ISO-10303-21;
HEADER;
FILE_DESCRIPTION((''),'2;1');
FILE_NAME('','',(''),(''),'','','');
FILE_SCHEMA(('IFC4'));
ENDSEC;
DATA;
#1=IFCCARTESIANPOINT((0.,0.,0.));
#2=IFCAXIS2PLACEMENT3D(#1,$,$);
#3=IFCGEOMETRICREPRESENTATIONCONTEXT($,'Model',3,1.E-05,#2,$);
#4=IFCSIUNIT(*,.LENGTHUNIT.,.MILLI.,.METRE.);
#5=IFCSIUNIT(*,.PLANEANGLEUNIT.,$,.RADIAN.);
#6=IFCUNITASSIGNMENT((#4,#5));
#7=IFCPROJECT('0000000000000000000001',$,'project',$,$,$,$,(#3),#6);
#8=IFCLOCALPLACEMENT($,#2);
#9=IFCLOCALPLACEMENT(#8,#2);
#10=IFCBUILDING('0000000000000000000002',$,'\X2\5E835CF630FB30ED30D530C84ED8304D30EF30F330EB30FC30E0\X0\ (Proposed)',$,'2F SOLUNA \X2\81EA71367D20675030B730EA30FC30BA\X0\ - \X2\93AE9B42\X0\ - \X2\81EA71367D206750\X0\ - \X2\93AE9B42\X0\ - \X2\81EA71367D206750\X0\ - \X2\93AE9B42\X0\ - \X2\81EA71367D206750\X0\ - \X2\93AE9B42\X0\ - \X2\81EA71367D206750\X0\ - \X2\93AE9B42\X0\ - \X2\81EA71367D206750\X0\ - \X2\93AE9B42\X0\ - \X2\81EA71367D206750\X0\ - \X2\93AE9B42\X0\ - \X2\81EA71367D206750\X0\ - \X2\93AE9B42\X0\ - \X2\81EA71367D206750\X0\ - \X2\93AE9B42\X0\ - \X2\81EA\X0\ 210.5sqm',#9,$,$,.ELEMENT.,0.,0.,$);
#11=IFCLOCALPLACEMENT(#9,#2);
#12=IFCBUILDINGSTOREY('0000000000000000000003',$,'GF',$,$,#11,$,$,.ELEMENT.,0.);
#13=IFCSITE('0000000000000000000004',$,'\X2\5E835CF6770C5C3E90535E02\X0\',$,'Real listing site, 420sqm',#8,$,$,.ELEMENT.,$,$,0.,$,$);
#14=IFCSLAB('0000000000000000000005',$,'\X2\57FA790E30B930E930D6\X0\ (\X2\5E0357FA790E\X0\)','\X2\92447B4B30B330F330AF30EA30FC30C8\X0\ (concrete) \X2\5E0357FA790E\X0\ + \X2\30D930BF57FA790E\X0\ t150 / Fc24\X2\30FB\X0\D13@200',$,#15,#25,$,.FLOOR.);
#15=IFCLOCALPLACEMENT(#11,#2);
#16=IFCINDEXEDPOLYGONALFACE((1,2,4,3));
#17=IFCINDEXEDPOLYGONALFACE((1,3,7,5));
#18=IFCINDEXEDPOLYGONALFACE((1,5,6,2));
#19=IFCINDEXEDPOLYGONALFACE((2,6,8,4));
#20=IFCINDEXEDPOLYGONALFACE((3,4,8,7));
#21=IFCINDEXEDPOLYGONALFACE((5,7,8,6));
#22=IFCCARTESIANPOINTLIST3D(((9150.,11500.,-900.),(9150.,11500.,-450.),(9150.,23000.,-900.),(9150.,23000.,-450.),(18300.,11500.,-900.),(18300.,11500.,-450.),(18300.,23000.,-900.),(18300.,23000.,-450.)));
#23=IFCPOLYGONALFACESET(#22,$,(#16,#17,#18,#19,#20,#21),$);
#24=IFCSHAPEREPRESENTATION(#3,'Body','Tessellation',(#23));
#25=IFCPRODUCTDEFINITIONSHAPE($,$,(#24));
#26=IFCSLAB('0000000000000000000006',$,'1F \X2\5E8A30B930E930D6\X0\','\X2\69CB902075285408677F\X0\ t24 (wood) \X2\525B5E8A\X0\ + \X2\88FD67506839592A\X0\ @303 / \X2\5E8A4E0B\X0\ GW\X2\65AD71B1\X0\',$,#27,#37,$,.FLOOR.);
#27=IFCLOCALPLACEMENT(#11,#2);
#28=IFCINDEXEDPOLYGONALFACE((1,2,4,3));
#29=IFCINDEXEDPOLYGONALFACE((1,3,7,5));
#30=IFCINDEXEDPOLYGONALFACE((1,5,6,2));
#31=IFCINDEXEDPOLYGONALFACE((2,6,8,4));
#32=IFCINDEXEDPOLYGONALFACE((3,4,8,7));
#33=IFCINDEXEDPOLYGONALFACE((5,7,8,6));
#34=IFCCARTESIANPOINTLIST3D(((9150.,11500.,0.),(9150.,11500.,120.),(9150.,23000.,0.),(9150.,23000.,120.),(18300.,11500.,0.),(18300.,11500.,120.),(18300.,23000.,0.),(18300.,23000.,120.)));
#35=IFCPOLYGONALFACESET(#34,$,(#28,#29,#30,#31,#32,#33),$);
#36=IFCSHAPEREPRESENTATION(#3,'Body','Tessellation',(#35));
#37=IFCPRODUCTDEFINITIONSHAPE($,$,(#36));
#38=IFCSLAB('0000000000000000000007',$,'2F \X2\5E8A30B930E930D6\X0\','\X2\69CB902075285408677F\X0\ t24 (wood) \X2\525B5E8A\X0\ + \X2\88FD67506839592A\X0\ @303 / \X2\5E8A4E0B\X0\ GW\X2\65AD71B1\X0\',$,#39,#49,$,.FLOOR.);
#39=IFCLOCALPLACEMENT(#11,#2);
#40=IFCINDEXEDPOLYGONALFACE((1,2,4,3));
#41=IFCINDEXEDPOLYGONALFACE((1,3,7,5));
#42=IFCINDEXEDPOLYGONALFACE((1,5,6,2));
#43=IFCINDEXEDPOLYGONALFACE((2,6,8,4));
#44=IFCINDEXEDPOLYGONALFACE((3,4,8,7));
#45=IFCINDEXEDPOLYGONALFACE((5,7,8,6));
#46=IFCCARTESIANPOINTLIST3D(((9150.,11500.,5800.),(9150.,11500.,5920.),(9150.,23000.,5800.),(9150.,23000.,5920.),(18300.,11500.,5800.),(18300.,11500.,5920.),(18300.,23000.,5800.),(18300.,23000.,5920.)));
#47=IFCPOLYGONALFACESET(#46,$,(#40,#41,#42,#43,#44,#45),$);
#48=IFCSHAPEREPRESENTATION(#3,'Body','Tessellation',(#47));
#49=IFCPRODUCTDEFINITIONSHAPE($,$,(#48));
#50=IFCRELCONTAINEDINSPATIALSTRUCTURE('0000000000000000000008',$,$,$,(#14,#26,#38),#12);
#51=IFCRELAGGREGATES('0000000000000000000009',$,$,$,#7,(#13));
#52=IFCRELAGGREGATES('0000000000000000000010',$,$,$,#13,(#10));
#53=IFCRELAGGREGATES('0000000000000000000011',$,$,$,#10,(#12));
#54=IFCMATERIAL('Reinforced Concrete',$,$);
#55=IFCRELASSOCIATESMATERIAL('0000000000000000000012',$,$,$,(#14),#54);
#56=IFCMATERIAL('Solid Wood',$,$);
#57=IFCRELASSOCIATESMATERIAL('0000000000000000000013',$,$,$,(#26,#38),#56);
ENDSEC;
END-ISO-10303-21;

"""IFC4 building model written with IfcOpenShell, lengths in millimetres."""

from ifc_helpers import new_model, si_unit, frame, frame_2d, origin, place, context, project, spatial, rectangle, extrude, material, element, save


model = new_model("IFC4")

# Units and contexts
model_context = context("Model", 3, precision=1e-05, world=origin())
ifc_project = project(units=[si_unit("LENGTHUNIT", "METRE", prefix="MILLI"), si_unit("PLANEANGLEUNIT", "RADIAN")], contexts=[model_context])

# Site, building, storey
site_placement = place(None, origin())
site = spatial("IfcSite", under=ifc_project, at=site_placement, Name="広島県尾道市", ObjectType="Real listing site, 420sqm", CompositionType="ELEMENT", RefElevation=0.0)
building_placement = place(site_placement, origin())
building = spatial("IfcBuilding", under=site, at=building_placement, Name="広島・ロフト付きワンルーム (Proposed)", ObjectType="2F SOLUNA 自然素材シリーズ - 鎮魂 - 自然素材 - 鎮魂 - 自然素材 - 鎮魂 - 自然素材 - 鎮魂 - 自然素材 - 鎮魂 - 自然素材 - 鎮魂 - 自然素材 - 鎮魂 - 自然素材 - 鎮魂 - 自然素材 - 鎮魂 - 自 210.5sqm", CompositionType="ELEMENT", ElevationOfRefHeight=0.0, ElevationOfTerrain=0.0)
storey_placement = place(building_placement, origin())
storey = spatial("IfcBuildingStorey", under=building, at=storey_placement, Name="GF", CompositionType="ELEMENT", Elevation=0.0)

# Shared definitions
ifc_material_1 = material(Name="Solid Wood")

# Slabs
ifc_material_2 = material(Name="Reinforced Concrete")
slab_1_placement = place(storey_placement, frame((4575.0, 5750.0, -450.0)))
element("IfcSlab", 1, at=slab_1_placement, inside=storey, material=ifc_material_2, Name="基礎スラブ (布基礎)", Description="鉄筋コンクリート (concrete) 布基礎 + ベタ基礎 t150 / Fc24・D13@200", PredefinedType="FLOOR", context=model_context, shape_type="SweptSolid", body=[
    extrude(rectangle(XDim=9150.0, YDim=11500.0, at=frame_2d((4575.0, 5750.0))), frame((4575.0, 5750.0, -450.0)), (0.0, 0.0, 1.0), 450.0),
])
slab_2_placement = place(storey_placement, frame((4575.0, 5750.0, 0.0)))
element("IfcSlab", 2, at=slab_2_placement, inside=storey, material=ifc_material_1, Name="1F 床スラブ", Description="構造用合板 t24 (wood) 剛床 + 製材根太 @303 / 床下 GW断熱", PredefinedType="FLOOR", context=model_context, shape_type="SweptSolid", body=[
    extrude(rectangle(XDim=9150.0, YDim=11500.0, at=frame_2d((4575.0, 5750.0))), frame((4575.0, 5750.0, 0.0)), (0.0, 0.0, 1.0), 120.0),
])
slab_3_placement = place(storey_placement, frame((4575.0, 5750.0, 2900.0)))
element("IfcSlab", 3, at=slab_3_placement, inside=storey, material=ifc_material_1, Name="2F 床スラブ", Description="構造用合板 t24 (wood) 剛床 + 製材根太 @303 / 床下 GW断熱", PredefinedType="FLOOR", context=model_context, shape_type="SweptSolid", body=[
    extrude(rectangle(XDim=9150.0, YDim=11500.0, at=frame_2d((4575.0, 5750.0))), frame((4575.0, 5750.0, 2900.0)), (0.0, 0.0, 1.0), 120.0),
])

save(model, "model.ifc")
